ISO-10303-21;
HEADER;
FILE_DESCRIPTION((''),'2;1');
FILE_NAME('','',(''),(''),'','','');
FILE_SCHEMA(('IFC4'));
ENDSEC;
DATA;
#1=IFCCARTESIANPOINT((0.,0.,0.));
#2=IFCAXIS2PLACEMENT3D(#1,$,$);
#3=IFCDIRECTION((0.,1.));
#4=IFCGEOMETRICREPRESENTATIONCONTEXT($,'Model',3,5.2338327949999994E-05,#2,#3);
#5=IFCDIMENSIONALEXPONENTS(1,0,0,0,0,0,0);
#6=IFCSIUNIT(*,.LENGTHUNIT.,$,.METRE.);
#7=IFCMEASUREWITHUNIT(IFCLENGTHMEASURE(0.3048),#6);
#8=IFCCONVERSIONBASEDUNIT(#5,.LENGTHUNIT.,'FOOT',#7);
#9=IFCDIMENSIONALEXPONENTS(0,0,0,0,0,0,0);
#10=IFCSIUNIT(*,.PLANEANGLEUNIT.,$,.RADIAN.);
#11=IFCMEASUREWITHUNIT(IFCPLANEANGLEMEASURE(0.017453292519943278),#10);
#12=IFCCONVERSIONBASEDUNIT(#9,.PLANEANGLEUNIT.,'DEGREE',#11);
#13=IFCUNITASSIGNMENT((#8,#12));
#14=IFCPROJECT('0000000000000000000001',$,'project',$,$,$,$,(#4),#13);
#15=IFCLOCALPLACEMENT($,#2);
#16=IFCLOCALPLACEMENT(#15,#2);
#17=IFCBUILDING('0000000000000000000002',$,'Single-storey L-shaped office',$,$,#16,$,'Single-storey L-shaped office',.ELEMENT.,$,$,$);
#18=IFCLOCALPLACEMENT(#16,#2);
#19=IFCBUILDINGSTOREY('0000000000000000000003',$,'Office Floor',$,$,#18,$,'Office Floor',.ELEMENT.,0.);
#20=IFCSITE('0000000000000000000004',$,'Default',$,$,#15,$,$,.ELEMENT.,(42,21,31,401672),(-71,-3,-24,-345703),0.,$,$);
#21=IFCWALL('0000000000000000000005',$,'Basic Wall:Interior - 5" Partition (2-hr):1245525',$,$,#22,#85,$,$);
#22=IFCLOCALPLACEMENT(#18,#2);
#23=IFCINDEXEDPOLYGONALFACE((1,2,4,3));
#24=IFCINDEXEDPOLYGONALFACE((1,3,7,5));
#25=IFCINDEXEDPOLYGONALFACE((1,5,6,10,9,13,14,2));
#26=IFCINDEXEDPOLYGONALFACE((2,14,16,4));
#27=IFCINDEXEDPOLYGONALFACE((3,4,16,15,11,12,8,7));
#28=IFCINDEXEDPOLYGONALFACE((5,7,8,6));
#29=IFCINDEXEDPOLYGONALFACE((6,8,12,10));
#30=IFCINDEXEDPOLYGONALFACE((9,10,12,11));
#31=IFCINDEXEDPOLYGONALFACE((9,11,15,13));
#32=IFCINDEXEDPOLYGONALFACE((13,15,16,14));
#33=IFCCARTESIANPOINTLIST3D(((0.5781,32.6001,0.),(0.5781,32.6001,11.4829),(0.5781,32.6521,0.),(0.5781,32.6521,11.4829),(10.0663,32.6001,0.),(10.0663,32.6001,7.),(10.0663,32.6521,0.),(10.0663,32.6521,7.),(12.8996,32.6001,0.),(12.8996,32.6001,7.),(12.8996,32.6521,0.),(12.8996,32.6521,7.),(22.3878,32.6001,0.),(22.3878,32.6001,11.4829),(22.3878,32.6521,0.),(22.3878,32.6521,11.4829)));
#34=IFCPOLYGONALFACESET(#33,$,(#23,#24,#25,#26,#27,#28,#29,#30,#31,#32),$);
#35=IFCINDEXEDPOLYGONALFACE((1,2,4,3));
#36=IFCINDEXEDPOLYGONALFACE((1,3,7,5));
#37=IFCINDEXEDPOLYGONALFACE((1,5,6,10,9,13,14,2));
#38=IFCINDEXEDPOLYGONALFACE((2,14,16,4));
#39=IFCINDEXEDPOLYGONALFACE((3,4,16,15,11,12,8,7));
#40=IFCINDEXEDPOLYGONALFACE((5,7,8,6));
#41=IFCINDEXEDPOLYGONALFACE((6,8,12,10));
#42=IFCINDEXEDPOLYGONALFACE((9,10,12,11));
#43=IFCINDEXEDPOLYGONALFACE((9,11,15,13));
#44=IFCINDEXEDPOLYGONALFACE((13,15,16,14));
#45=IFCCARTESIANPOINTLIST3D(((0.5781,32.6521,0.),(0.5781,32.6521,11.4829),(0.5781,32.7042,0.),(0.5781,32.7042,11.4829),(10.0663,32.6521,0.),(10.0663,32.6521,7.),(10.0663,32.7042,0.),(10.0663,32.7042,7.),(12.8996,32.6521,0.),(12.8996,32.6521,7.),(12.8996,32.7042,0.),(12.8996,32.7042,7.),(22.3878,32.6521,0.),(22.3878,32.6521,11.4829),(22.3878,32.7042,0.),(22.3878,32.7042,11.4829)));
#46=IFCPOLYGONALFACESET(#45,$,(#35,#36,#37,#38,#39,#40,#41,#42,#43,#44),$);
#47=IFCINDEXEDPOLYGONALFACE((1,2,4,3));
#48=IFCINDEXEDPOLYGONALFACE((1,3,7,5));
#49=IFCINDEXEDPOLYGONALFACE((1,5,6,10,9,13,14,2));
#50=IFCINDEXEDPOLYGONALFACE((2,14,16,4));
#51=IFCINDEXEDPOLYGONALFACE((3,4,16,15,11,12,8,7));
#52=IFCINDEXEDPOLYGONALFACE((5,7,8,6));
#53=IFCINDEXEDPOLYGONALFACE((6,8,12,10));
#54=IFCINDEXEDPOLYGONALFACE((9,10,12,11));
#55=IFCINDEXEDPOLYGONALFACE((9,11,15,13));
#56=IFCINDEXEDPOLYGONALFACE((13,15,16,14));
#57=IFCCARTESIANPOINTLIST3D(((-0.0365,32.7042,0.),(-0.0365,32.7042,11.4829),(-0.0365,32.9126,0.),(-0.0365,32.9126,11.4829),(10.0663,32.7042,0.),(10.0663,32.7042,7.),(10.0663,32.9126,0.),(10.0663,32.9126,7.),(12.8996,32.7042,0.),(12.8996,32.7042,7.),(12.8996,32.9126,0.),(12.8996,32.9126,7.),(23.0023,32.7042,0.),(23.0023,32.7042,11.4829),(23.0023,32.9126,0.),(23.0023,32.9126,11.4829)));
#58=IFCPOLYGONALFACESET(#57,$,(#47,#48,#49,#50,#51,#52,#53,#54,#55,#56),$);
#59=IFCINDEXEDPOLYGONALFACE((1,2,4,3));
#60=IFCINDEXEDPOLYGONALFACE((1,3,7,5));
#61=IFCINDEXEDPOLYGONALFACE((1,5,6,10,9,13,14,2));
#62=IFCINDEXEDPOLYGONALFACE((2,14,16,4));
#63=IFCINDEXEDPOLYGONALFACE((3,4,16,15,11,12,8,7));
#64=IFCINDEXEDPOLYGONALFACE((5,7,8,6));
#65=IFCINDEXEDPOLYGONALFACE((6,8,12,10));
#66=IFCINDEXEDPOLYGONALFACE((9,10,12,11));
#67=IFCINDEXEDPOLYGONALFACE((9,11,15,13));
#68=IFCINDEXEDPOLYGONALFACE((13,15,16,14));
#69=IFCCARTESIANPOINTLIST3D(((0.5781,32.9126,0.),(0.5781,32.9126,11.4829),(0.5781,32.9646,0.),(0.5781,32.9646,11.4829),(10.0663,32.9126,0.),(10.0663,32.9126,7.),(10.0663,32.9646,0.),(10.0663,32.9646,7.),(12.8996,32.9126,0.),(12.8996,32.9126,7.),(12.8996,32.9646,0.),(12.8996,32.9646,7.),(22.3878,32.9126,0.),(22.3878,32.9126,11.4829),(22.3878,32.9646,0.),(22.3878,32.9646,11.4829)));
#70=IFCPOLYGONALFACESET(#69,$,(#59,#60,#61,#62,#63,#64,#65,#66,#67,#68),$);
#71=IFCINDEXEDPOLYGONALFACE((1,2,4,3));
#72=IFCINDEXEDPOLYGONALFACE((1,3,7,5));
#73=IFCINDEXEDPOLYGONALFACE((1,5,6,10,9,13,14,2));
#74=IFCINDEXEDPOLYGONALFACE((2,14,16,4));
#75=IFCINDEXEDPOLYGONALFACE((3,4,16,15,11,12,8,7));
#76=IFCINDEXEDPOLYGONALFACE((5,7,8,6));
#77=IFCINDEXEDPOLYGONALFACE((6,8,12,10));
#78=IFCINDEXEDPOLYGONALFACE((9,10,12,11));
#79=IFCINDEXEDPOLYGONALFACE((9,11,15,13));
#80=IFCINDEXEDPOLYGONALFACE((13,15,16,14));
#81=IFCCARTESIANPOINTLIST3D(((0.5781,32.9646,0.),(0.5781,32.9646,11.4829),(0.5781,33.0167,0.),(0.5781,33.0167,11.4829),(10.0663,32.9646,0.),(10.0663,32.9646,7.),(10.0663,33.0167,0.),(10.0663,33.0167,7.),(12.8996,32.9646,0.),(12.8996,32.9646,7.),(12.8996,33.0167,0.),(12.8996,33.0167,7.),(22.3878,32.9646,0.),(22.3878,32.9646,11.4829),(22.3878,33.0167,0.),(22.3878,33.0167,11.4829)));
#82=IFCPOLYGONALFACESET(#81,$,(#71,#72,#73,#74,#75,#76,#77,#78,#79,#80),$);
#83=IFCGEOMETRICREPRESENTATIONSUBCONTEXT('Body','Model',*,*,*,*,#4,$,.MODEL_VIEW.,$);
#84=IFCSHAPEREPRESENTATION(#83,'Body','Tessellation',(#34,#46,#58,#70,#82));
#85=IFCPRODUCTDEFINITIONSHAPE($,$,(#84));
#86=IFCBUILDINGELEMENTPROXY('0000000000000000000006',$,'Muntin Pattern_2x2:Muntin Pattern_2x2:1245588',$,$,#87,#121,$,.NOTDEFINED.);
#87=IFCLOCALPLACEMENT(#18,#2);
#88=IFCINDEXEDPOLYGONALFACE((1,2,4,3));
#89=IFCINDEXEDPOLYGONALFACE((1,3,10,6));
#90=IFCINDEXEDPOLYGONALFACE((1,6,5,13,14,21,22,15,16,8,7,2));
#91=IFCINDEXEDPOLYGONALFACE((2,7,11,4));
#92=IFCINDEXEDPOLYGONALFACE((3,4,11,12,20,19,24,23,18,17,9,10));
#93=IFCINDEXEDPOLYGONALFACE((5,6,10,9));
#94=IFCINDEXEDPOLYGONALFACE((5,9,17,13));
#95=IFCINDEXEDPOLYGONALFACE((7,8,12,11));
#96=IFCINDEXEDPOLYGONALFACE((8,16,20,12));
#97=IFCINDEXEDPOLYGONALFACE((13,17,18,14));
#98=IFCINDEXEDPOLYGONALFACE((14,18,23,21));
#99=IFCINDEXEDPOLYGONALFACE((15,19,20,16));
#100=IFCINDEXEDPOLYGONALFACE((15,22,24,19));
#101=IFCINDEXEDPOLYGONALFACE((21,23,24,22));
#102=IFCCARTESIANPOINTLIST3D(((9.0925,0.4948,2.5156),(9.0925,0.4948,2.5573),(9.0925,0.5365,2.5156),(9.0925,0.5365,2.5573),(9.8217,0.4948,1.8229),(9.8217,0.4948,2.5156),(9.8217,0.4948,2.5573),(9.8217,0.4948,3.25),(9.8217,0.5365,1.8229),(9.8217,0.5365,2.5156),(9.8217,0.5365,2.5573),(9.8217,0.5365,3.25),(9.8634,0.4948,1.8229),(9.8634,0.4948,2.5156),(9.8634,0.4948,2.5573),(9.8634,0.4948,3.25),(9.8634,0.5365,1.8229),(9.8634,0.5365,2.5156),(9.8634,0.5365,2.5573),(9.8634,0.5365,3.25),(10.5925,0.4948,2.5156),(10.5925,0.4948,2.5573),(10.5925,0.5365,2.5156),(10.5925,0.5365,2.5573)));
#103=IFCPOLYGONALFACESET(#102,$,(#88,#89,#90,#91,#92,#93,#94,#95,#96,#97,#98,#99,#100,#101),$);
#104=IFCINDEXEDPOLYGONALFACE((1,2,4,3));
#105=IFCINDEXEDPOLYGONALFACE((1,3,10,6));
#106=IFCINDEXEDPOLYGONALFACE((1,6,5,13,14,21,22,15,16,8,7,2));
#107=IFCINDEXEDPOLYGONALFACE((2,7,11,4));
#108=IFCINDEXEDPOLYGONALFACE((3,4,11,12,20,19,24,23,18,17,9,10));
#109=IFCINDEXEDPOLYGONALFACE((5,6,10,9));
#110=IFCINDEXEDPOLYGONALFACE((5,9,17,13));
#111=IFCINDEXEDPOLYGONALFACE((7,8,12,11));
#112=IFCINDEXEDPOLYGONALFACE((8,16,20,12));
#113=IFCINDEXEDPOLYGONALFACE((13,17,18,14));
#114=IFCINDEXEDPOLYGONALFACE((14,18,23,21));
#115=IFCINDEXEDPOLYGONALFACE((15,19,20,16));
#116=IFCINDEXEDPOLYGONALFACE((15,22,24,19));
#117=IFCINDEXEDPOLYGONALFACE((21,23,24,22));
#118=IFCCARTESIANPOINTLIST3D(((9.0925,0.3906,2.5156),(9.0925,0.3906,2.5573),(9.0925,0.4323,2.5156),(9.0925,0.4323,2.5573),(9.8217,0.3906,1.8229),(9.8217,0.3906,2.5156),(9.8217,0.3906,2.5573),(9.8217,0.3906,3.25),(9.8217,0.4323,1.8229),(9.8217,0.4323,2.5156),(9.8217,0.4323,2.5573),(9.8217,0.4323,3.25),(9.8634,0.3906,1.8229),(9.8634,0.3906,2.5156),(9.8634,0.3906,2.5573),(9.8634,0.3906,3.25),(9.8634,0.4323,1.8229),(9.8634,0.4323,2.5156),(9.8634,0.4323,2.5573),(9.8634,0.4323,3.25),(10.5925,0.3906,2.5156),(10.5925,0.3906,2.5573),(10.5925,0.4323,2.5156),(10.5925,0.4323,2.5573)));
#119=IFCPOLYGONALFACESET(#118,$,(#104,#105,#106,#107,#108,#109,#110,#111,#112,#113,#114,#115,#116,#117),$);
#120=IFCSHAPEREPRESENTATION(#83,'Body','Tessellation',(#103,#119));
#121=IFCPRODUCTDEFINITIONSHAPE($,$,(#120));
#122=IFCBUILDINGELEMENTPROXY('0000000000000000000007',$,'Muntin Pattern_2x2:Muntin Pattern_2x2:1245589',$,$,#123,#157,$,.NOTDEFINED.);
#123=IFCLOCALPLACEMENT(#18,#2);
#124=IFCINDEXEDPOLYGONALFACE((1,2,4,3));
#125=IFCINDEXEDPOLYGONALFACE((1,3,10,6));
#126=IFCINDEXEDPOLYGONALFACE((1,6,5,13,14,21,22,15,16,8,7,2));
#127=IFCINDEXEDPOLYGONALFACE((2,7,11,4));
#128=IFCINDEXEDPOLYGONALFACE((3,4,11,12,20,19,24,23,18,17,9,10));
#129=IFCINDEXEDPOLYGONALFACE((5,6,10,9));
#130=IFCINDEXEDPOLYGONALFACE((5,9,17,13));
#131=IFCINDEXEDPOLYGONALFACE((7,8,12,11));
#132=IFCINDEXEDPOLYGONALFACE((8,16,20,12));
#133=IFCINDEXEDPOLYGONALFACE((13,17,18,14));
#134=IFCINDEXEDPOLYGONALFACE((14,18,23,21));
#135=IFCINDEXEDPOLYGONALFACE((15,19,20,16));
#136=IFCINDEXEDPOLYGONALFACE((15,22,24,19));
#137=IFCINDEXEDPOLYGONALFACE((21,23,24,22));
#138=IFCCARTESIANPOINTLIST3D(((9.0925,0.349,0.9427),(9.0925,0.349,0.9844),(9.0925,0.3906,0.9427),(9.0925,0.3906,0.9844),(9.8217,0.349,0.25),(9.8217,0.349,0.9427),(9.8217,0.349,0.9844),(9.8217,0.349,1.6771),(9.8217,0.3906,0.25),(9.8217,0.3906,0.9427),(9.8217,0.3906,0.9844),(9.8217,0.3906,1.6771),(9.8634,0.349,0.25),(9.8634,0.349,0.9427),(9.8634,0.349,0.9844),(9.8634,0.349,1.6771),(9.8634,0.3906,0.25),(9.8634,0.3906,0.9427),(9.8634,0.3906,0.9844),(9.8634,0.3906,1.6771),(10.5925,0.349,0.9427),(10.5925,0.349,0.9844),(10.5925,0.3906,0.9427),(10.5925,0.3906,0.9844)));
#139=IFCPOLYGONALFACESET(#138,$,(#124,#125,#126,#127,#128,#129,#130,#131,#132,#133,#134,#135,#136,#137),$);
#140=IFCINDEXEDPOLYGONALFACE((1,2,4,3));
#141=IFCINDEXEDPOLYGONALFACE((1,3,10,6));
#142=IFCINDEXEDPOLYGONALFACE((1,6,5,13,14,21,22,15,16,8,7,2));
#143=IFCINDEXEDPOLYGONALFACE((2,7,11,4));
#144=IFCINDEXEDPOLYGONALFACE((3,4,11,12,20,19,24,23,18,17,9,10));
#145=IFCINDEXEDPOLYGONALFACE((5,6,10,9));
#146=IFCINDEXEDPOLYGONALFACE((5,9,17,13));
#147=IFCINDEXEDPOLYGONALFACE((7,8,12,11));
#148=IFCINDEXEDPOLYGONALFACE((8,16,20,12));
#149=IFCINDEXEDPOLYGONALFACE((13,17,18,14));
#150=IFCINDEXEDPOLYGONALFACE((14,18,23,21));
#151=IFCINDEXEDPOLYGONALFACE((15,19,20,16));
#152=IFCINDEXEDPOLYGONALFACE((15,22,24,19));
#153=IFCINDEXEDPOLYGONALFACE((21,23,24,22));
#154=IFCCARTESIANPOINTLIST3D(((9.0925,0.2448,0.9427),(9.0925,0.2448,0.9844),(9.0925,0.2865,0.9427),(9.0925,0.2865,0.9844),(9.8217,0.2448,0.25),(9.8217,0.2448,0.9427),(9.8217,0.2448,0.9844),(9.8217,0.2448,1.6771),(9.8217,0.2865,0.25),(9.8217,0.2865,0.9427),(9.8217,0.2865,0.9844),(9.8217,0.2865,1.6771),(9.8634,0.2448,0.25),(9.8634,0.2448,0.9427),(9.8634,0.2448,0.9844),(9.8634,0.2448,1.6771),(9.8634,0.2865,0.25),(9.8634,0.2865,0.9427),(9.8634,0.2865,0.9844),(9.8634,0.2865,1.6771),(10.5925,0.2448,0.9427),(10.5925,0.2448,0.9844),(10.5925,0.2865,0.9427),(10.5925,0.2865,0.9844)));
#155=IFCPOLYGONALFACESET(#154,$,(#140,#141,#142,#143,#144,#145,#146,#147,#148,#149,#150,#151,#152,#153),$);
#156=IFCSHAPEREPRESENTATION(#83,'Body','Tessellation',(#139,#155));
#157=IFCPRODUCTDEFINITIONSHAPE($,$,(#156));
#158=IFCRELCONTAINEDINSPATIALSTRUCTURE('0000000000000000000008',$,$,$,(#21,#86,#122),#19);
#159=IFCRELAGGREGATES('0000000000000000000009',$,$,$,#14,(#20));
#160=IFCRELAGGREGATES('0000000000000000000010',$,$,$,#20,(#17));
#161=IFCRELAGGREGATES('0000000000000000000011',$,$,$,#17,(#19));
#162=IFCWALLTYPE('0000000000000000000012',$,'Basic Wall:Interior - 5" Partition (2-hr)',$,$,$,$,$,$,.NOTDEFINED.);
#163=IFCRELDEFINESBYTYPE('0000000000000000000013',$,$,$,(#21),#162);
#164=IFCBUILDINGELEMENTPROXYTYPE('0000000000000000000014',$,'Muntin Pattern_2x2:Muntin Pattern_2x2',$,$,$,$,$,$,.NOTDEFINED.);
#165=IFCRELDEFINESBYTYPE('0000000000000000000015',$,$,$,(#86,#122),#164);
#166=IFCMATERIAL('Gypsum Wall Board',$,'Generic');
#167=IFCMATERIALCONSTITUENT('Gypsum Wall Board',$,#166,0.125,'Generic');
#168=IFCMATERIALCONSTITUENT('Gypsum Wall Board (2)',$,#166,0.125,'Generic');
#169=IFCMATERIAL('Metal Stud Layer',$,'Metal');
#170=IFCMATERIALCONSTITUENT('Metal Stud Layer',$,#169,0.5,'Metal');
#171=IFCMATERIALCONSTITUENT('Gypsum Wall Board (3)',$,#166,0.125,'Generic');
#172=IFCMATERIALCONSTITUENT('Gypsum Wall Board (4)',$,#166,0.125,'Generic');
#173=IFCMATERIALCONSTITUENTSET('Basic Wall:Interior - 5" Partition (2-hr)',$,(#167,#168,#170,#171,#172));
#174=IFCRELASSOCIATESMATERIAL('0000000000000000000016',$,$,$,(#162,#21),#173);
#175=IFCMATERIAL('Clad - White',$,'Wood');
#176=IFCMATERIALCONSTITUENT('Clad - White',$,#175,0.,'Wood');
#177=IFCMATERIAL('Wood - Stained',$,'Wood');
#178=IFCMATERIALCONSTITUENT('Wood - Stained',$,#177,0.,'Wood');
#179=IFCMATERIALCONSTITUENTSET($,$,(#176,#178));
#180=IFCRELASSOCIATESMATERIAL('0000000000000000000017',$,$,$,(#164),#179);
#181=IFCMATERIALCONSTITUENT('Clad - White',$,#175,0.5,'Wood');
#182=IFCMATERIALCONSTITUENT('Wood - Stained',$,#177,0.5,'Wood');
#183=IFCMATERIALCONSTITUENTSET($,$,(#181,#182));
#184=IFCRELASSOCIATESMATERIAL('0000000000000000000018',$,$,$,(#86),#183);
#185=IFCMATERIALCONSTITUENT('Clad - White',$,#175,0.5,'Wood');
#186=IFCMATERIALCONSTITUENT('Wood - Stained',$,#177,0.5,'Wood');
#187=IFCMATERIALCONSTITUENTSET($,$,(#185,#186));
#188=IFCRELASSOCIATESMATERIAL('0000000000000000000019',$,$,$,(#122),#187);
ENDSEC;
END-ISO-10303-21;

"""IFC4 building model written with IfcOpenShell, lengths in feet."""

from ifc_helpers import new_model, entity, si_unit, converted_unit, direction, frame, origin, place, context, subcontext, project, spatial, indexed_curve, outline, extrude, source, transform, mapped, material, constituent, constituent_set, type_object, type_shapes, element, save


model = new_model("IFC4")

# Units and contexts
model_context = context("Model", 3, precision=5.2338327949999994e-05, world=origin(), true_north=direction((0.0, 1.0)))
body_context = subcontext(model_context, "Body", "Model", "MODEL_VIEW")
ifc_project = project(units=[converted_unit("LENGTHUNIT", "FOOT", entity("IfcLengthMeasure", 0.3048), si_unit("LENGTHUNIT", "METRE"), dimensions=[1, 0, 0, 0, 0, 0, 0]), converted_unit("PLANEANGLEUNIT", "DEGREE", entity("IfcPlaneAngleMeasure", 0.017453292519943278), si_unit("PLANEANGLEUNIT", "RADIAN"), dimensions=[0, 0, 0, 0, 0, 0, 0])], contexts=[model_context])

# Site, building, storey
site_placement = place(None, origin())
site = spatial("IfcSite", under=ifc_project, at=site_placement, Name="Default", CompositionType="ELEMENT", RefLatitude=(42, 21, 31, 401672), RefLongitude=(-71, -3, -24, -345703), RefElevation=0.0)
building_placement = place(site_placement, origin())
building = spatial("IfcBuilding", under=site, at=building_placement, Name="Single-storey L-shaped office", LongName="Single-storey L-shaped office", CompositionType="ELEMENT")
storey_placement = place(building_placement, origin())
storey = spatial("IfcBuildingStorey", under=building, at=storey_placement, Name="Office Floor", LongName="Office Floor", CompositionType="ELEMENT", Elevation=0.0)

# Shared definitions
ifc_material_1 = material(Name="Metal Stud Layer", Category="Metal")
ifc_material_2 = material(Name="Gypsum Wall Board", Category="Generic")
ifc_material_3 = material(Name="Wood - Stained", Category="Wood")

# Wall, opening
ifc_constituent_1 = constituent(ifc_material_2, Name="Gypsum Wall Board", Category="Generic", fraction=0.125)
ifc_constituent_2 = constituent(ifc_material_2, Name="Gypsum Wall Board (2)", Category="Generic", fraction=0.125)
ifc_constituent_3 = constituent(ifc_material_1, Name="Metal Stud Layer", Category="Metal", fraction=0.5)
ifc_constituent_4 = constituent(ifc_material_2, Name="Gypsum Wall Board (3)", Category="Generic", fraction=0.125)
ifc_constituent_5 = constituent(ifc_material_2, Name="Gypsum Wall Board (4)", Category="Generic", fraction=0.125)
ifc_constituent_set_1 = constituent_set(constituents=[ifc_constituent_1, ifc_constituent_2, ifc_constituent_3, ifc_constituent_4, ifc_constituent_5], Name="Basic Wall:Interior - 5\" Partition (2-hr)")
wall_type_1 = type_object("IfcWallType", Name="Basic Wall:Interior - 5\" Partition (2-hr)", PredefinedType="NOTDEFINED", material=ifc_constituent_set_1)
wall_1_placement = place(storey_placement, frame((0.5781, 32.8084, 0.0)))
wall_1 = element("IfcWall", 1, at=wall_1_placement, inside=storey, type_object=wall_type_1, material=ifc_constituent_set_1, Name="Basic Wall:Interior - 5\" Partition (2-hr):1245525", context=body_context, shape_type="SweptSolid", body=[
    extrude(outline(indexed_curve([(-6.8622, -10.9048), (4.6207, -10.9048), (4.6207, -1.4167), (-2.3793, -1.4167), (-2.3793, 1.4167), (4.6207, 1.4167), (4.6207, 10.9048), (-6.8622, 10.9048), (-6.8622, -10.9048)], self_intersect=False)), frame((10.9048, -0.2083, 4.6207), z_axis=(0.0, 1.0, 0.0), x_axis=(0.0, 0.0, -1.0)), (0.0, 0.0, 1.0), 0.0521),
    extrude(outline(indexed_curve([(-4.6207, -10.9048), (6.8622, -10.9048), (6.8622, 10.9048), (-4.6207, 10.9048), (-4.6207, 1.4167), (2.3793, 1.4167), (2.3793, -1.4167), (-4.6207, -1.4167), (-4.6207, -10.9048)], self_intersect=False)), frame((10.9048, -0.1562, 4.6207), z_axis=(0.0, 1.0, 0.0), x_axis=(0.0, 0.0, 1.0)), (0.0, 0.0, 1.0), 0.0521),
    extrude(outline(indexed_curve([(-4.6207, -11.5194), (6.8622, -11.5194), (6.8622, 11.5194), (-4.6207, 11.5194), (-4.6207, 1.4167), (2.3793, 1.4167), (2.3793, -1.4167), (-4.6207, -1.4167), (-4.6207, -11.5194)], self_intersect=False)), frame((10.9048, -0.1042, 4.6207), z_axis=(0.0, 1.0, 0.0), x_axis=(0.0, 0.0, 1.0)), (0.0, 0.0, 1.0), 0.2083),
    extrude(outline(indexed_curve([(-4.6207, -10.9048), (6.8622, -10.9048), (6.8622, 10.9048), (-4.6207, 10.9048), (-4.6207, 1.4167), (2.3793, 1.4167), (2.3793, -1.4167), (-4.6207, -1.4167), (-4.6207, -10.9048)], self_intersect=False)), frame((10.9048, 0.1042, 4.6207), z_axis=(0.0, 1.0, 0.0), x_axis=(0.0, 0.0, 1.0)), (0.0, 0.0, 1.0), 0.0521),
    extrude(outline(indexed_curve([(-4.6207, -10.9048), (6.8622, -10.9048), (6.8622, 10.9048), (-4.6207, 10.9048), (-4.6207, 1.4167), (2.3793, 1.4167), (2.3793, -1.4167), (-4.6207, -1.4167), (-4.6207, -10.9048)], self_intersect=False)), frame((10.9048, 0.1562, 4.6207), z_axis=(0.0, 1.0, 0.0), x_axis=(0.0, 0.0, 1.0)), (0.0, 0.0, 1.0), 0.0521),
])
opening_1_placement = place(wall_1_placement, frame((9.4881, -0.2083, 0.0)))
element("IfcOpeningElement", 2, at=opening_1_placement, cuts=wall_1, PredefinedType="OPENING", context=body_context, shape_type="SweptSolid", body=[
    extrude(outline(indexed_curve([(0.0, 2.8333), (0.0, 0.0), (7.0, 0.0), (7.0, 2.8333), (0.0, 2.8333)], self_intersect=False)), frame((0.0, 0.0, 0.0), z_axis=(0.0, 1.0, 0.0), x_axis=(0.0, 0.0, 1.0)), (0.0, 0.0, 1.0), 0.4167),
])

# Building element proxies
ifc_material_4 = material(Name="Clad - White", Category="Wood")
ifc_constituent_6 = constituent(ifc_material_4, Name="Clad - White", Category="Wood", fraction=0.5)
ifc_constituent_7 = constituent(ifc_material_3, Name="Wood - Stained", Category="Wood", fraction=0.5)
ifc_constituent_set_2 = constituent_set(constituents=[ifc_constituent_6, ifc_constituent_7])
ifc_constituent_8 = constituent(ifc_material_4, Name="Clad - White", Category="Wood", fraction=0.0)
ifc_constituent_9 = constituent(ifc_material_3, Name="Wood - Stained", Category="Wood", fraction=0.0)
ifc_constituent_set_3 = constituent_set(constituents=[ifc_constituent_8, ifc_constituent_9])
building_element_proxy_type_1 = type_object("IfcBuildingElementProxyType", Name="Muntin Pattern_2x2:Muntin Pattern_2x2", PredefinedType="NOTDEFINED", material=ifc_constituent_set_3)
shared_shape_1 = source(origin(), body_context, "Body", "SweptSolid", [
    extrude(outline(indexed_curve([(0.0208, -0.0208), (0.7135, -0.0208), (0.7135, 0.0208), (0.0208, 0.0208), (0.0208, 0.75), (-0.0208, 0.75), (-0.0208, 0.0208), (-0.7135, 0.0208), (-0.7135, -0.0208), (-0.0208, -0.0208), (-0.0208, -0.75), (0.0208, -0.75), (0.0208, -0.0208)], self_intersect=False)), frame((0.0, 0.0312, 0.7135), z_axis=(0.0, 1.0, 0.0), x_axis=(0.0, 0.0, 1.0)), (0.0, 0.0, 1.0), 0.0417),
    extrude(outline(indexed_curve([(0.0208, -0.0208), (0.7135, -0.0208), (0.7135, 0.0208), (0.0208, 0.0208), (0.0208, 0.75), (-0.0208, 0.75), (-0.0208, 0.0208), (-0.7135, 0.0208), (-0.7135, -0.0208), (-0.0208, -0.0208), (-0.0208, -0.75), (0.0208, -0.75), (0.0208, -0.0208)], self_intersect=False)), frame((0.0, -0.0729, 0.7135), z_axis=(0.0, 1.0, 0.0), x_axis=(0.0, 0.0, 1.0)), (0.0, 0.0, 1.0), 0.0417),
])
type_shapes(building_element_proxy_type_1, [shared_shape_1])
proxy_1_placement = place(storey_placement, frame((9.8425, 0.4635, 1.8229)))
element("IfcBuildingElementProxy", 3, at=proxy_1_placement, inside=storey, type_object=building_element_proxy_type_1, material=ifc_constituent_set_2, Name="Muntin Pattern_2x2:Muntin Pattern_2x2:1245588", PredefinedType="NOTDEFINED", context=body_context, shape_type="MappedRepresentation", body=[
    mapped(shared_shape_1, transform((0.0, 0.0, 0.0), scale=1.0)),
])
ifc_constituent_10 = constituent(ifc_material_4, Name="Clad - White", Category="Wood", fraction=0.5)
ifc_constituent_11 = constituent(ifc_material_3, Name="Wood - Stained", Category="Wood", fraction=0.5)
ifc_constituent_set_4 = constituent_set(constituents=[ifc_constituent_10, ifc_constituent_11])
proxy_2_placement = place(storey_placement, frame((9.8425, 0.3177, 0.25)))
element("IfcBuildingElementProxy", 4, at=proxy_2_placement, inside=storey, type_object=building_element_proxy_type_1, material=ifc_constituent_set_4, Name="Muntin Pattern_2x2:Muntin Pattern_2x2:1245589", PredefinedType="NOTDEFINED", context=body_context, shape_type="MappedRepresentation", body=[
    mapped(shared_shape_1, transform((0.0, 0.0, 0.0), scale=1.0)),
])

save(model, "model.ifc")
